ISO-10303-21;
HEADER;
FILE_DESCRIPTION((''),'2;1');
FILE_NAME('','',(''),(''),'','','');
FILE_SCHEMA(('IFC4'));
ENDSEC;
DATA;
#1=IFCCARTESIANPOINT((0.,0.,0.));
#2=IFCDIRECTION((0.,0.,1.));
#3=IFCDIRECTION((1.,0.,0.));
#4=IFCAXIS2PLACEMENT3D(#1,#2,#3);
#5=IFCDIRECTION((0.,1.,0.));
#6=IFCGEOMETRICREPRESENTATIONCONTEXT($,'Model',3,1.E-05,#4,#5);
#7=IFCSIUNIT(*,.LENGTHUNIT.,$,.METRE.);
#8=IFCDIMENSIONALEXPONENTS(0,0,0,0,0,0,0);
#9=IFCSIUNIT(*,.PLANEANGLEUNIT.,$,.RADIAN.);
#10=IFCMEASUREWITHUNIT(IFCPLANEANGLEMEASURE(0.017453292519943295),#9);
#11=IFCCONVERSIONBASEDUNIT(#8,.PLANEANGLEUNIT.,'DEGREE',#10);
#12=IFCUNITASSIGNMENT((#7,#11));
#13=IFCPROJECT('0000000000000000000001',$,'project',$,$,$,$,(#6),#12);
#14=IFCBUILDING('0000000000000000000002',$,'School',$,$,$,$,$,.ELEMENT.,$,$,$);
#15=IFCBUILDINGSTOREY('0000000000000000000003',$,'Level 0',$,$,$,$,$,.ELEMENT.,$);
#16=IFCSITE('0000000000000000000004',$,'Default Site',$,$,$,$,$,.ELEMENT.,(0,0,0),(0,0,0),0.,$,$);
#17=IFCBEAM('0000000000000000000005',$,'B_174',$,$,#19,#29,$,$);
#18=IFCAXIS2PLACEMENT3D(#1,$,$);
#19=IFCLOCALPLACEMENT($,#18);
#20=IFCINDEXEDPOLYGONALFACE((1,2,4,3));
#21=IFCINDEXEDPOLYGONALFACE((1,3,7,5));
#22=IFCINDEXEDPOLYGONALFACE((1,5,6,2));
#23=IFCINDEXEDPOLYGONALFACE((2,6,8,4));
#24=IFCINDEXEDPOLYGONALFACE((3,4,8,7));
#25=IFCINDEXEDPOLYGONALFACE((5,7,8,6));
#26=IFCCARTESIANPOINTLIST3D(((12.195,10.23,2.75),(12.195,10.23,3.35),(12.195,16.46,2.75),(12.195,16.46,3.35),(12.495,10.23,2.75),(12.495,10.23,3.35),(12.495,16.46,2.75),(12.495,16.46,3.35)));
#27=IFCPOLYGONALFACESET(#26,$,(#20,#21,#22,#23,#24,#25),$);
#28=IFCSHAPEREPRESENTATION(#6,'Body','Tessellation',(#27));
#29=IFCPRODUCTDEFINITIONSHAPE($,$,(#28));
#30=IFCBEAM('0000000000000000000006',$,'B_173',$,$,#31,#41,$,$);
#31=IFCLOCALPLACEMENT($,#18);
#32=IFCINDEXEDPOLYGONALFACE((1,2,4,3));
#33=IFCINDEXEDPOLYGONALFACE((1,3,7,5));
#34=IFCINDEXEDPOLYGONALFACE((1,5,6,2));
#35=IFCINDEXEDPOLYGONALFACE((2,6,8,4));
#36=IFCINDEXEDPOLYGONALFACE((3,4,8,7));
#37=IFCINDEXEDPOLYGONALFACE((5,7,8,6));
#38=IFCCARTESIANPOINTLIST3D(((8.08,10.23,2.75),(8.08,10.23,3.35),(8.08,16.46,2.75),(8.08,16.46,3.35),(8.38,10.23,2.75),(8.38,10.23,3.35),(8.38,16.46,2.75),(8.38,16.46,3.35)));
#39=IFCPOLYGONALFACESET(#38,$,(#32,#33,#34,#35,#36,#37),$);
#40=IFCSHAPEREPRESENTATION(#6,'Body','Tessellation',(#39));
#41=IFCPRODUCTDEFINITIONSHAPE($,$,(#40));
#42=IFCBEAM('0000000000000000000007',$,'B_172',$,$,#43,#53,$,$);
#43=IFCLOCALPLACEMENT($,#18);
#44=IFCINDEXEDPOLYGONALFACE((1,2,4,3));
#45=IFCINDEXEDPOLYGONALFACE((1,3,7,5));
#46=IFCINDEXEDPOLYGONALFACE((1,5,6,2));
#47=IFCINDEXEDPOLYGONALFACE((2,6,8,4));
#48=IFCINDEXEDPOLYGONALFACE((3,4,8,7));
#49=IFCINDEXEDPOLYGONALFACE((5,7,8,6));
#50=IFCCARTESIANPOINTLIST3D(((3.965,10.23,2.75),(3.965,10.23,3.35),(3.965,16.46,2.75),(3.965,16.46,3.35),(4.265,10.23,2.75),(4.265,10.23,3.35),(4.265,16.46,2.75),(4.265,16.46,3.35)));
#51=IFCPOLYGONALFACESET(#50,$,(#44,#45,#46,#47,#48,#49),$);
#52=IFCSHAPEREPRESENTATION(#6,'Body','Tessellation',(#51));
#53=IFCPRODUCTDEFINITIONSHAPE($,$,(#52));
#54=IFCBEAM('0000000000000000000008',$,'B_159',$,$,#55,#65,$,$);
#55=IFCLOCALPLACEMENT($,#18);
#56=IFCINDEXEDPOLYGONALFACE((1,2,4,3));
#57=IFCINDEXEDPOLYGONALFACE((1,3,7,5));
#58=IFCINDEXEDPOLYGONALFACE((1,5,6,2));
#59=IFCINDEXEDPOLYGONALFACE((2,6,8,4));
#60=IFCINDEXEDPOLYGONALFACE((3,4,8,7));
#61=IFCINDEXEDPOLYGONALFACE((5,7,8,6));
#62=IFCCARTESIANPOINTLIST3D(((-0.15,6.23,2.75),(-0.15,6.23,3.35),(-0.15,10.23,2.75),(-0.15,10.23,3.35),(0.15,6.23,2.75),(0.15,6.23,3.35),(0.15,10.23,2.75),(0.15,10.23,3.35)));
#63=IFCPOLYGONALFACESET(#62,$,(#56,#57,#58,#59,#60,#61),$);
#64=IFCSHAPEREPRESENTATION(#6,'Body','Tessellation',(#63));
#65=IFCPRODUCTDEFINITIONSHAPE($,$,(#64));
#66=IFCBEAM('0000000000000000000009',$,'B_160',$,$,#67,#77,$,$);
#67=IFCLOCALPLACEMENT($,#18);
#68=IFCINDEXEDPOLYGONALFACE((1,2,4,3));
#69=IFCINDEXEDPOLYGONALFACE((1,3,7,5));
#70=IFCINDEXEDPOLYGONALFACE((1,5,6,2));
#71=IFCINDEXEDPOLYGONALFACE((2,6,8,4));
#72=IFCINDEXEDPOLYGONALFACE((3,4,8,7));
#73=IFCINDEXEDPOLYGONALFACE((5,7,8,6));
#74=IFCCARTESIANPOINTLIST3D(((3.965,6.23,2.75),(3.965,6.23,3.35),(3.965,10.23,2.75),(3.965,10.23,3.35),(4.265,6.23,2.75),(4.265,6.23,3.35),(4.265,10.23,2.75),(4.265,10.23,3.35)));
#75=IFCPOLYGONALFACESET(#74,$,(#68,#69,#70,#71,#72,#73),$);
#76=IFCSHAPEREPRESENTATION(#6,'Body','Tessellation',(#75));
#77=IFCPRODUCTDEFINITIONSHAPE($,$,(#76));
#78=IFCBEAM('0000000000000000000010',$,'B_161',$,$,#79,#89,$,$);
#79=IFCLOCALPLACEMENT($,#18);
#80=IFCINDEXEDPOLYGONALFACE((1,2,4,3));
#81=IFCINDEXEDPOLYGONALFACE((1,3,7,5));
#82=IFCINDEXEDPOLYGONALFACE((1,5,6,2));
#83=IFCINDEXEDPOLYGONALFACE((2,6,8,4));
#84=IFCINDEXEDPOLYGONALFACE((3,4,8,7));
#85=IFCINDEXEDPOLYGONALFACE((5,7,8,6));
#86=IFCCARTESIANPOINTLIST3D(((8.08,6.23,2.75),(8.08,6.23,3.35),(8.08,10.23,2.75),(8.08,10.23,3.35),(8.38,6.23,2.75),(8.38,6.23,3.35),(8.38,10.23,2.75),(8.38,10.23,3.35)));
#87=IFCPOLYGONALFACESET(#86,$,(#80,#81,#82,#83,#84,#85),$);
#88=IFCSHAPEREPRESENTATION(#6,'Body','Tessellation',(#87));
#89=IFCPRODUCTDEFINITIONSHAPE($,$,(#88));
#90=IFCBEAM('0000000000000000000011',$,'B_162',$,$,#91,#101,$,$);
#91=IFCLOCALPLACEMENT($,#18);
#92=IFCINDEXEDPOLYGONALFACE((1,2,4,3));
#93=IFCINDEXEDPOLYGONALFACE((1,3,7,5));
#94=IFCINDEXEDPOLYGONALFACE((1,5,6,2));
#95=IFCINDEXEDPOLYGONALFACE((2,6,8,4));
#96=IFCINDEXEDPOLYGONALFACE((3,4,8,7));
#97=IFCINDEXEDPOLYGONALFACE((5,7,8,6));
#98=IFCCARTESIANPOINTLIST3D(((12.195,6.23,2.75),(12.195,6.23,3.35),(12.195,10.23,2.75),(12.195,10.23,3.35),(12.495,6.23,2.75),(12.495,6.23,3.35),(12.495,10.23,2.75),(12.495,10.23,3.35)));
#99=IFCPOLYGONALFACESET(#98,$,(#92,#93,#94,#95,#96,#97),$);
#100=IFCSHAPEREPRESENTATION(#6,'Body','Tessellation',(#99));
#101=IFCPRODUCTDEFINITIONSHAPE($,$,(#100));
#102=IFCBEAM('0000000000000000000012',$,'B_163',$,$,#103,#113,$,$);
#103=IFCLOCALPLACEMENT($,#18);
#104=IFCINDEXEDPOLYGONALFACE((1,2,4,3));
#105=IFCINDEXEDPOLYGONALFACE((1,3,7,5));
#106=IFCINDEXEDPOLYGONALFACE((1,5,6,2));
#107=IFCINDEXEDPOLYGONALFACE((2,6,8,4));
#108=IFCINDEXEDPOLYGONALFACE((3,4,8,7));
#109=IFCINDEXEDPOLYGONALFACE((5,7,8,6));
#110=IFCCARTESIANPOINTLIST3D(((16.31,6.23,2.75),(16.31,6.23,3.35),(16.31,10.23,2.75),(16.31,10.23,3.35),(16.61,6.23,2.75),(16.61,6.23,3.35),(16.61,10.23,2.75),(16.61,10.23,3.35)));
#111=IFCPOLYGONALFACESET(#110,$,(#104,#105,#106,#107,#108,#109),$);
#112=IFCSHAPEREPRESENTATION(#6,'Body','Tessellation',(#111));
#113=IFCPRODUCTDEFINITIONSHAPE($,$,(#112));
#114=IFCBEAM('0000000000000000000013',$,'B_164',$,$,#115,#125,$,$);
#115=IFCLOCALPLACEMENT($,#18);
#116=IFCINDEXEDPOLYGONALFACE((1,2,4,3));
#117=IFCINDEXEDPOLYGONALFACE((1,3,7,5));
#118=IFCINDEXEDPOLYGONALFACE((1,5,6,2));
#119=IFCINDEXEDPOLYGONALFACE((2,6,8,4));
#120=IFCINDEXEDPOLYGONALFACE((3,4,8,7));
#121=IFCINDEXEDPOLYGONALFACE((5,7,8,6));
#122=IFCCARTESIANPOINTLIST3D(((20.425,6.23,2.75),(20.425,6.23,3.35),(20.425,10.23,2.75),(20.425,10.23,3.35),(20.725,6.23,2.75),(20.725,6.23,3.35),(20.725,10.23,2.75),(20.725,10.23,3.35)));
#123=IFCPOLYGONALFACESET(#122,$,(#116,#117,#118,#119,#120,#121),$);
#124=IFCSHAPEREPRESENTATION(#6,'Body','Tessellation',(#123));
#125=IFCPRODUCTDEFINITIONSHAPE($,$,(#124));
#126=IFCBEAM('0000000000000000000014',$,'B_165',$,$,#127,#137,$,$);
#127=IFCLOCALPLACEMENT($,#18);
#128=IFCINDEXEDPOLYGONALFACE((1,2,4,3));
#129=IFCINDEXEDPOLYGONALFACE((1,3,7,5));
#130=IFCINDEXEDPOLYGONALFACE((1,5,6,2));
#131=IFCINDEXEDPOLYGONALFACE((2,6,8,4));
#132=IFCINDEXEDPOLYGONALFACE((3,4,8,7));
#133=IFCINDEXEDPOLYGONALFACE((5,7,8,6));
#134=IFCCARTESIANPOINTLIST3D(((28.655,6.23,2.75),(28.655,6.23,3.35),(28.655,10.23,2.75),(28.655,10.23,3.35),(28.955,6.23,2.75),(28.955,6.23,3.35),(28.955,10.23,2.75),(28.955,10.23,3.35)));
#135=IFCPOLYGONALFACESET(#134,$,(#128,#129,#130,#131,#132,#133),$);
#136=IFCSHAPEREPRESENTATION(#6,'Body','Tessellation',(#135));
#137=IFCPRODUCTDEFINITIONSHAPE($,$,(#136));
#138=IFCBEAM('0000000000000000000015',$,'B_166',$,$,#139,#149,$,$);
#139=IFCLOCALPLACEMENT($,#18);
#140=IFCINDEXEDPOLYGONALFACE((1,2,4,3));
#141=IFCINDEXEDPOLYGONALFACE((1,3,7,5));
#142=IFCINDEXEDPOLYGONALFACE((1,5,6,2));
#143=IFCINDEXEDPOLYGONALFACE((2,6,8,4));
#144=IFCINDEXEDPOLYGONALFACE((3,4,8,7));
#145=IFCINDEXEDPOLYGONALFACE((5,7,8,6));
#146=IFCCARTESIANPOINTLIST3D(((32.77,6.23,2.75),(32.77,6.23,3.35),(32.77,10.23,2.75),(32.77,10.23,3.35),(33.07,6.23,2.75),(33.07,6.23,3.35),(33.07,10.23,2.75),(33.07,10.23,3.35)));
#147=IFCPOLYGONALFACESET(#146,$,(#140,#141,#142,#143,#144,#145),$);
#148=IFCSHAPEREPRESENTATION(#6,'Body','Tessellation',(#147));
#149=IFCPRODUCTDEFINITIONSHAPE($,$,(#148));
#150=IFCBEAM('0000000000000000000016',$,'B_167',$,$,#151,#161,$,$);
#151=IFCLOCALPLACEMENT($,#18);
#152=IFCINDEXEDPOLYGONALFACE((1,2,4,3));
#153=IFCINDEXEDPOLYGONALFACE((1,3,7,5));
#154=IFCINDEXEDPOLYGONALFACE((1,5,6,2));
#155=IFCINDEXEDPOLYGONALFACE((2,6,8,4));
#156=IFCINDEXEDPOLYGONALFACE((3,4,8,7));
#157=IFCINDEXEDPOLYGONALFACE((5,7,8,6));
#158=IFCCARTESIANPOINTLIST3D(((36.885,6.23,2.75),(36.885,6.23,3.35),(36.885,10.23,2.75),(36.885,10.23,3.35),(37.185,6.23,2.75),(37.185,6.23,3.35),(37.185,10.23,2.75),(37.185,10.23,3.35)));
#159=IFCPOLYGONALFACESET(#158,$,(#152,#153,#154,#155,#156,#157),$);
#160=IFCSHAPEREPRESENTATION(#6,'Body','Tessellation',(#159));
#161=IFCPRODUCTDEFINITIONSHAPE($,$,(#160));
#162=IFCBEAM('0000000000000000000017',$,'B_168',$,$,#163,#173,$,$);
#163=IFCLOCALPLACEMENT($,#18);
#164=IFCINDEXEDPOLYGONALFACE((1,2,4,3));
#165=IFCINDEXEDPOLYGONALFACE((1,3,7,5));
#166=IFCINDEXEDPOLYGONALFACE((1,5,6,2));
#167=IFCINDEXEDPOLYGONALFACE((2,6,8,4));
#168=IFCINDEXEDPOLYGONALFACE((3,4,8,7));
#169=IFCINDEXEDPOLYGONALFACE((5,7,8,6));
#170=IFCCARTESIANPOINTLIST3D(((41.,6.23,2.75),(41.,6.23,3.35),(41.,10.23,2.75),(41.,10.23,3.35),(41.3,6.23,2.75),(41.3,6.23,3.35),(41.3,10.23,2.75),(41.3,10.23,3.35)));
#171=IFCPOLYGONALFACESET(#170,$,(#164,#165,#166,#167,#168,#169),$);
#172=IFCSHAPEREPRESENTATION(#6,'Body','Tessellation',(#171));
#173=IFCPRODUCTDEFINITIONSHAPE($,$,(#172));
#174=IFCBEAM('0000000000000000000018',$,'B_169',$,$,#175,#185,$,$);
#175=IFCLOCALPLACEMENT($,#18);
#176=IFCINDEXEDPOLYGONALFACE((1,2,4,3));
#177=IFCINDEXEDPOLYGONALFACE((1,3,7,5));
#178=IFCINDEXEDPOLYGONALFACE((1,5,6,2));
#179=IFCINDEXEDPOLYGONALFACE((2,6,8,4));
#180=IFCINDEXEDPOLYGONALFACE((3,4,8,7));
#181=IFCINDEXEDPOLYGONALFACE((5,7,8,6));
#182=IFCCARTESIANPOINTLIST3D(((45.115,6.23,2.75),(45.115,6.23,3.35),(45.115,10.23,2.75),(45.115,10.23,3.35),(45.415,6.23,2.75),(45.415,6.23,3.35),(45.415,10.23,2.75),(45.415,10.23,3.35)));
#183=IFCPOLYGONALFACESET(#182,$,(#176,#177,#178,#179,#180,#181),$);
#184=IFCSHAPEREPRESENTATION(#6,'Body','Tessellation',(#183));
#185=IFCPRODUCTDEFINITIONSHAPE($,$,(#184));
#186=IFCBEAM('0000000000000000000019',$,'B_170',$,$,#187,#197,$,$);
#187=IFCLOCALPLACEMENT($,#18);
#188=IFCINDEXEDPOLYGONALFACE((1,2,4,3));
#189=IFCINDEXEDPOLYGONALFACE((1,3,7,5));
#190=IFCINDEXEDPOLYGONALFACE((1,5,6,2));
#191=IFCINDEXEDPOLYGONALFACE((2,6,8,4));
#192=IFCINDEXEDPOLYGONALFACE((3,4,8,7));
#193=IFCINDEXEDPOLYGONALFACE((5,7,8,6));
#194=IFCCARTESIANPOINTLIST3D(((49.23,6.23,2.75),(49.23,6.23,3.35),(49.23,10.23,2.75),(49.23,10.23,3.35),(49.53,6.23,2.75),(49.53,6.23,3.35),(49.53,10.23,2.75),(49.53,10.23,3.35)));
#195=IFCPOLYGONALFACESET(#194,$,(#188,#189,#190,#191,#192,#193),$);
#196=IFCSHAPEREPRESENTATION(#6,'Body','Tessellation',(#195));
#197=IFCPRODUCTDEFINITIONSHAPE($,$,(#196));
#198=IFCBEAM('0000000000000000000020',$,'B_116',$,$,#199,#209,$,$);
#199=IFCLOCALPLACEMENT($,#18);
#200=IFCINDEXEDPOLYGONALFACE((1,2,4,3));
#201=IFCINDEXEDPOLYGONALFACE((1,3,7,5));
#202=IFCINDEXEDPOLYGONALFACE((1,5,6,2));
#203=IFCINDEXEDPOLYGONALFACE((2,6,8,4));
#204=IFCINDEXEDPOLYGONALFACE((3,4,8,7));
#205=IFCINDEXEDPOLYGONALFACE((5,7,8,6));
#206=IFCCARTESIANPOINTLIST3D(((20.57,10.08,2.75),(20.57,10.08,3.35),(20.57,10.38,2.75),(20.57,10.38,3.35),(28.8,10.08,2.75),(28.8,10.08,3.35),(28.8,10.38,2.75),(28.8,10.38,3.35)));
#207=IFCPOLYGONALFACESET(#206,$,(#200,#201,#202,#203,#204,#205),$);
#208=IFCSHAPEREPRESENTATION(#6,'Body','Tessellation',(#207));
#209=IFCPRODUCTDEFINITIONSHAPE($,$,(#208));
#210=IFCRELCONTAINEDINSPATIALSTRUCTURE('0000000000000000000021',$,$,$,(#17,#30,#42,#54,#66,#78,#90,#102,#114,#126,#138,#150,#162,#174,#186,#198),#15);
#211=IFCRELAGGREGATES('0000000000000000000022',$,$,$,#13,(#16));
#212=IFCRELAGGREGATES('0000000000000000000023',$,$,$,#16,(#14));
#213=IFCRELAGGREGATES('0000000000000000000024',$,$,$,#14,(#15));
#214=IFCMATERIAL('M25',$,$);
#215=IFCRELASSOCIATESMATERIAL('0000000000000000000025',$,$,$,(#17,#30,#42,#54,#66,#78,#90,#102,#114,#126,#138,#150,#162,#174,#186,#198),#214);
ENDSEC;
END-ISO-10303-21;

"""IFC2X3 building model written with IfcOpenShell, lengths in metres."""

from ifc_helpers import new_model, entity, si_unit, converted_unit, direction, frame, frame_2d, origin_with_axes, place, context, project, spatial, rectangle, extrude, material, element, save


model = new_model("IFC2X3")

# Units and contexts
model_context = context("Model", 3, precision=1e-05, world=origin_with_axes(), true_north=direction((0.0, 1.0, 0.0)))
ifc_project = project(units=[si_unit("LENGTHUNIT", "METRE"), converted_unit("PLANEANGLEUNIT", "DEGREE", entity("IfcPlaneAngleMeasure", 0.017453292519943295), si_unit("PLANEANGLEUNIT", "RADIAN"), dimensions=[0, 0, 0, 0, 0, 0, 0])], contexts=[model_context])

# Site, building, storey
site = spatial("IfcSite", under=ifc_project, Name="Default Site", CompositionType="ELEMENT", RefLatitude=(0, 0, 0), RefLongitude=(0, 0, 0), RefElevation=0.0)
building = spatial("IfcBuilding", under=site, Name="School", CompositionType="ELEMENT")
storey = spatial("IfcBuildingStorey", under=building, Name="Level 0", CompositionType="ELEMENT")

# Shared definitions
ifc_material = material(Name="M25")
placement = place(None, origin_with_axes())

# Beams
element("IfcBeam", 1, at=placement, inside=storey, material=ifc_material, Name="B_174", context=model_context, shape_type="SweptSolid", body=[
    extrude(rectangle(XDim=0.3, YDim=0.6, at=frame_2d((0.0, 0.0), x_axis=(0.0, 1.0, 0.0))), frame((12.345, 10.23, 3.05), z_axis=(0.0, 1.0, 0.0), x_axis=(0.0, 0.0, -1.0)), (0.0, 0.0, 1.0), 6.23),
])
element("IfcBeam", 2, at=placement, inside=storey, material=ifc_material, Name="B_173", context=model_context, shape_type="SweptSolid", body=[
    extrude(rectangle(XDim=0.3, YDim=0.6, at=frame_2d((0.0, 0.0), x_axis=(0.0, 1.0, 0.0))), frame((8.23, 10.23, 3.05), z_axis=(0.0, 1.0, 0.0), x_axis=(0.0, 0.0, -1.0)), (0.0, 0.0, 1.0), 6.23),
])
element("IfcBeam", 3, at=placement, inside=storey, material=ifc_material, Name="B_172", context=model_context, shape_type="SweptSolid", body=[
    extrude(rectangle(XDim=0.3, YDim=0.6, at=frame_2d((0.0, 0.0), x_axis=(0.0, 1.0, 0.0))), frame((4.115, 10.23, 3.05), z_axis=(0.0, 1.0, 0.0), x_axis=(0.0, 0.0, -1.0)), (0.0, 0.0, 1.0), 6.23),
])
element("IfcBeam", 4, at=placement, inside=storey, material=ifc_material, Name="B_159", context=model_context, shape_type="SweptSolid", body=[
    extrude(rectangle(XDim=0.3, YDim=0.6, at=frame_2d((0.0, 0.0), x_axis=(0.0, 1.0, 0.0))), frame((0.0, 6.23, 3.05), z_axis=(0.0, 1.0, 0.0), x_axis=(0.0, 0.0, -1.0)), (0.0, 0.0, 1.0), 4.0),
])
element("IfcBeam", 5, at=placement, inside=storey, material=ifc_material, Name="B_160", context=model_context, shape_type="SweptSolid", body=[
    extrude(rectangle(XDim=0.3, YDim=0.6, at=frame_2d((0.0, 0.0), x_axis=(0.0, 1.0, 0.0))), frame((4.115, 6.23, 3.05), z_axis=(0.0, 1.0, 0.0), x_axis=(0.0, 0.0, -1.0)), (0.0, 0.0, 1.0), 4.0),
])
element("IfcBeam", 6, at=placement, inside=storey, material=ifc_material, Name="B_161", context=model_context, shape_type="SweptSolid", body=[
    extrude(rectangle(XDim=0.3, YDim=0.6, at=frame_2d((0.0, 0.0), x_axis=(0.0, 1.0, 0.0))), frame((8.23, 6.23, 3.05), z_axis=(0.0, 1.0, 0.0), x_axis=(0.0, 0.0, -1.0)), (0.0, 0.0, 1.0), 4.0),
])
element("IfcBeam", 7, at=placement, inside=storey, material=ifc_material, Name="B_162", context=model_context, shape_type="SweptSolid", body=[
    extrude(rectangle(XDim=0.3, YDim=0.6, at=frame_2d((0.0, 0.0), x_axis=(0.0, 1.0, 0.0))), frame((12.345, 6.23, 3.05), z_axis=(0.0, 1.0, 0.0), x_axis=(0.0, 0.0, -1.0)), (0.0, 0.0, 1.0), 4.0),
])
element("IfcBeam", 8, at=placement, inside=storey, material=ifc_material, Name="B_163", context=model_context, shape_type="SweptSolid", body=[
    extrude(rectangle(XDim=0.3, YDim=0.6, at=frame_2d((0.0, 0.0), x_axis=(0.0, 1.0, 0.0))), frame((16.46, 6.23, 3.05), z_axis=(0.0, 1.0, 0.0), x_axis=(0.0, 0.0, -1.0)), (0.0, 0.0, 1.0), 4.0),
])
element("IfcBeam", 9, at=placement, inside=storey, material=ifc_material, Name="B_164", context=model_context, shape_type="SweptSolid", body=[
    extrude(rectangle(XDim=0.3, YDim=0.6, at=frame_2d((0.0, 0.0), x_axis=(0.0, 1.0, 0.0))), frame((20.575, 6.23, 3.05), z_axis=(0.0, 1.0, 0.0), x_axis=(0.0, 0.0, -1.0)), (0.0, 0.0, 1.0), 4.0),
])
element("IfcBeam", 10, at=placement, inside=storey, material=ifc_material, Name="B_165", context=model_context, shape_type="SweptSolid", body=[
    extrude(rectangle(XDim=0.3, YDim=0.6, at=frame_2d((0.0, 0.0), x_axis=(0.0, 1.0, 0.0))), frame((28.805, 6.23, 3.05), z_axis=(0.0, 1.0, 0.0), x_axis=(0.0, 0.0, -1.0)), (0.0, 0.0, 1.0), 4.0),
])
element("IfcBeam", 11, at=placement, inside=storey, material=ifc_material, Name="B_166", context=model_context, shape_type="SweptSolid", body=[
    extrude(rectangle(XDim=0.3, YDim=0.6, at=frame_2d((0.0, 0.0), x_axis=(0.0, 1.0, 0.0))), frame((32.92, 6.23, 3.05), z_axis=(0.0, 1.0, 0.0), x_axis=(0.0, 0.0, -1.0)), (0.0, 0.0, 1.0), 4.0),
])
element("IfcBeam", 12, at=placement, inside=storey, material=ifc_material, Name="B_167", context=model_context, shape_type="SweptSolid", body=[
    extrude(rectangle(XDim=0.3, YDim=0.6, at=frame_2d((0.0, 0.0), x_axis=(0.0, 1.0, 0.0))), frame((37.035, 6.23, 3.05), z_axis=(0.0, 1.0, 0.0), x_axis=(0.0, 0.0, -1.0)), (0.0, 0.0, 1.0), 4.0),
])
element("IfcBeam", 13, at=placement, inside=storey, material=ifc_material, Name="B_168", context=model_context, shape_type="SweptSolid", body=[
    extrude(rectangle(XDim=0.3, YDim=0.6, at=frame_2d((0.0, 0.0), x_axis=(0.0, 1.0, 0.0))), frame((41.15, 6.23, 3.05), z_axis=(0.0, 1.0, 0.0), x_axis=(0.0, 0.0, -1.0)), (0.0, 0.0, 1.0), 4.0),
])
element("IfcBeam", 14, at=placement, inside=storey, material=ifc_material, Name="B_169", context=model_context, shape_type="SweptSolid", body=[
    extrude(rectangle(XDim=0.3, YDim=0.6, at=frame_2d((0.0, 0.0), x_axis=(0.0, 1.0, 0.0))), frame((45.265, 6.23, 3.05), z_axis=(0.0, 1.0, 0.0), x_axis=(0.0, 0.0, -1.0)), (0.0, 0.0, 1.0), 4.0),
])
element("IfcBeam", 15, at=placement, inside=storey, material=ifc_material, Name="B_170", context=model_context, shape_type="SweptSolid", body=[
    extrude(rectangle(XDim=0.3, YDim=0.6, at=frame_2d((0.0, 0.0), x_axis=(0.0, 1.0, 0.0))), frame((49.38, 6.23, 3.05), z_axis=(0.0, 1.0, 0.0), x_axis=(0.0, 0.0, -1.0)), (0.0, 0.0, 1.0), 4.0),
])
element("IfcBeam", 16, at=placement, inside=storey, material=ifc_material, Name="B_116", context=model_context, shape_type="SweptSolid", body=[
    extrude(rectangle(XDim=0.3, YDim=0.6, at=frame_2d((0.0, 0.0), x_axis=(0.0, 1.0, 0.0))), frame((20.57, 10.23, 3.05), z_axis=(1.0, 0.0, 0.0), x_axis=(0.0, 0.0, -1.0)), (0.0, 0.0, 1.0), 8.23),
])

save(model, "model.ifc")
